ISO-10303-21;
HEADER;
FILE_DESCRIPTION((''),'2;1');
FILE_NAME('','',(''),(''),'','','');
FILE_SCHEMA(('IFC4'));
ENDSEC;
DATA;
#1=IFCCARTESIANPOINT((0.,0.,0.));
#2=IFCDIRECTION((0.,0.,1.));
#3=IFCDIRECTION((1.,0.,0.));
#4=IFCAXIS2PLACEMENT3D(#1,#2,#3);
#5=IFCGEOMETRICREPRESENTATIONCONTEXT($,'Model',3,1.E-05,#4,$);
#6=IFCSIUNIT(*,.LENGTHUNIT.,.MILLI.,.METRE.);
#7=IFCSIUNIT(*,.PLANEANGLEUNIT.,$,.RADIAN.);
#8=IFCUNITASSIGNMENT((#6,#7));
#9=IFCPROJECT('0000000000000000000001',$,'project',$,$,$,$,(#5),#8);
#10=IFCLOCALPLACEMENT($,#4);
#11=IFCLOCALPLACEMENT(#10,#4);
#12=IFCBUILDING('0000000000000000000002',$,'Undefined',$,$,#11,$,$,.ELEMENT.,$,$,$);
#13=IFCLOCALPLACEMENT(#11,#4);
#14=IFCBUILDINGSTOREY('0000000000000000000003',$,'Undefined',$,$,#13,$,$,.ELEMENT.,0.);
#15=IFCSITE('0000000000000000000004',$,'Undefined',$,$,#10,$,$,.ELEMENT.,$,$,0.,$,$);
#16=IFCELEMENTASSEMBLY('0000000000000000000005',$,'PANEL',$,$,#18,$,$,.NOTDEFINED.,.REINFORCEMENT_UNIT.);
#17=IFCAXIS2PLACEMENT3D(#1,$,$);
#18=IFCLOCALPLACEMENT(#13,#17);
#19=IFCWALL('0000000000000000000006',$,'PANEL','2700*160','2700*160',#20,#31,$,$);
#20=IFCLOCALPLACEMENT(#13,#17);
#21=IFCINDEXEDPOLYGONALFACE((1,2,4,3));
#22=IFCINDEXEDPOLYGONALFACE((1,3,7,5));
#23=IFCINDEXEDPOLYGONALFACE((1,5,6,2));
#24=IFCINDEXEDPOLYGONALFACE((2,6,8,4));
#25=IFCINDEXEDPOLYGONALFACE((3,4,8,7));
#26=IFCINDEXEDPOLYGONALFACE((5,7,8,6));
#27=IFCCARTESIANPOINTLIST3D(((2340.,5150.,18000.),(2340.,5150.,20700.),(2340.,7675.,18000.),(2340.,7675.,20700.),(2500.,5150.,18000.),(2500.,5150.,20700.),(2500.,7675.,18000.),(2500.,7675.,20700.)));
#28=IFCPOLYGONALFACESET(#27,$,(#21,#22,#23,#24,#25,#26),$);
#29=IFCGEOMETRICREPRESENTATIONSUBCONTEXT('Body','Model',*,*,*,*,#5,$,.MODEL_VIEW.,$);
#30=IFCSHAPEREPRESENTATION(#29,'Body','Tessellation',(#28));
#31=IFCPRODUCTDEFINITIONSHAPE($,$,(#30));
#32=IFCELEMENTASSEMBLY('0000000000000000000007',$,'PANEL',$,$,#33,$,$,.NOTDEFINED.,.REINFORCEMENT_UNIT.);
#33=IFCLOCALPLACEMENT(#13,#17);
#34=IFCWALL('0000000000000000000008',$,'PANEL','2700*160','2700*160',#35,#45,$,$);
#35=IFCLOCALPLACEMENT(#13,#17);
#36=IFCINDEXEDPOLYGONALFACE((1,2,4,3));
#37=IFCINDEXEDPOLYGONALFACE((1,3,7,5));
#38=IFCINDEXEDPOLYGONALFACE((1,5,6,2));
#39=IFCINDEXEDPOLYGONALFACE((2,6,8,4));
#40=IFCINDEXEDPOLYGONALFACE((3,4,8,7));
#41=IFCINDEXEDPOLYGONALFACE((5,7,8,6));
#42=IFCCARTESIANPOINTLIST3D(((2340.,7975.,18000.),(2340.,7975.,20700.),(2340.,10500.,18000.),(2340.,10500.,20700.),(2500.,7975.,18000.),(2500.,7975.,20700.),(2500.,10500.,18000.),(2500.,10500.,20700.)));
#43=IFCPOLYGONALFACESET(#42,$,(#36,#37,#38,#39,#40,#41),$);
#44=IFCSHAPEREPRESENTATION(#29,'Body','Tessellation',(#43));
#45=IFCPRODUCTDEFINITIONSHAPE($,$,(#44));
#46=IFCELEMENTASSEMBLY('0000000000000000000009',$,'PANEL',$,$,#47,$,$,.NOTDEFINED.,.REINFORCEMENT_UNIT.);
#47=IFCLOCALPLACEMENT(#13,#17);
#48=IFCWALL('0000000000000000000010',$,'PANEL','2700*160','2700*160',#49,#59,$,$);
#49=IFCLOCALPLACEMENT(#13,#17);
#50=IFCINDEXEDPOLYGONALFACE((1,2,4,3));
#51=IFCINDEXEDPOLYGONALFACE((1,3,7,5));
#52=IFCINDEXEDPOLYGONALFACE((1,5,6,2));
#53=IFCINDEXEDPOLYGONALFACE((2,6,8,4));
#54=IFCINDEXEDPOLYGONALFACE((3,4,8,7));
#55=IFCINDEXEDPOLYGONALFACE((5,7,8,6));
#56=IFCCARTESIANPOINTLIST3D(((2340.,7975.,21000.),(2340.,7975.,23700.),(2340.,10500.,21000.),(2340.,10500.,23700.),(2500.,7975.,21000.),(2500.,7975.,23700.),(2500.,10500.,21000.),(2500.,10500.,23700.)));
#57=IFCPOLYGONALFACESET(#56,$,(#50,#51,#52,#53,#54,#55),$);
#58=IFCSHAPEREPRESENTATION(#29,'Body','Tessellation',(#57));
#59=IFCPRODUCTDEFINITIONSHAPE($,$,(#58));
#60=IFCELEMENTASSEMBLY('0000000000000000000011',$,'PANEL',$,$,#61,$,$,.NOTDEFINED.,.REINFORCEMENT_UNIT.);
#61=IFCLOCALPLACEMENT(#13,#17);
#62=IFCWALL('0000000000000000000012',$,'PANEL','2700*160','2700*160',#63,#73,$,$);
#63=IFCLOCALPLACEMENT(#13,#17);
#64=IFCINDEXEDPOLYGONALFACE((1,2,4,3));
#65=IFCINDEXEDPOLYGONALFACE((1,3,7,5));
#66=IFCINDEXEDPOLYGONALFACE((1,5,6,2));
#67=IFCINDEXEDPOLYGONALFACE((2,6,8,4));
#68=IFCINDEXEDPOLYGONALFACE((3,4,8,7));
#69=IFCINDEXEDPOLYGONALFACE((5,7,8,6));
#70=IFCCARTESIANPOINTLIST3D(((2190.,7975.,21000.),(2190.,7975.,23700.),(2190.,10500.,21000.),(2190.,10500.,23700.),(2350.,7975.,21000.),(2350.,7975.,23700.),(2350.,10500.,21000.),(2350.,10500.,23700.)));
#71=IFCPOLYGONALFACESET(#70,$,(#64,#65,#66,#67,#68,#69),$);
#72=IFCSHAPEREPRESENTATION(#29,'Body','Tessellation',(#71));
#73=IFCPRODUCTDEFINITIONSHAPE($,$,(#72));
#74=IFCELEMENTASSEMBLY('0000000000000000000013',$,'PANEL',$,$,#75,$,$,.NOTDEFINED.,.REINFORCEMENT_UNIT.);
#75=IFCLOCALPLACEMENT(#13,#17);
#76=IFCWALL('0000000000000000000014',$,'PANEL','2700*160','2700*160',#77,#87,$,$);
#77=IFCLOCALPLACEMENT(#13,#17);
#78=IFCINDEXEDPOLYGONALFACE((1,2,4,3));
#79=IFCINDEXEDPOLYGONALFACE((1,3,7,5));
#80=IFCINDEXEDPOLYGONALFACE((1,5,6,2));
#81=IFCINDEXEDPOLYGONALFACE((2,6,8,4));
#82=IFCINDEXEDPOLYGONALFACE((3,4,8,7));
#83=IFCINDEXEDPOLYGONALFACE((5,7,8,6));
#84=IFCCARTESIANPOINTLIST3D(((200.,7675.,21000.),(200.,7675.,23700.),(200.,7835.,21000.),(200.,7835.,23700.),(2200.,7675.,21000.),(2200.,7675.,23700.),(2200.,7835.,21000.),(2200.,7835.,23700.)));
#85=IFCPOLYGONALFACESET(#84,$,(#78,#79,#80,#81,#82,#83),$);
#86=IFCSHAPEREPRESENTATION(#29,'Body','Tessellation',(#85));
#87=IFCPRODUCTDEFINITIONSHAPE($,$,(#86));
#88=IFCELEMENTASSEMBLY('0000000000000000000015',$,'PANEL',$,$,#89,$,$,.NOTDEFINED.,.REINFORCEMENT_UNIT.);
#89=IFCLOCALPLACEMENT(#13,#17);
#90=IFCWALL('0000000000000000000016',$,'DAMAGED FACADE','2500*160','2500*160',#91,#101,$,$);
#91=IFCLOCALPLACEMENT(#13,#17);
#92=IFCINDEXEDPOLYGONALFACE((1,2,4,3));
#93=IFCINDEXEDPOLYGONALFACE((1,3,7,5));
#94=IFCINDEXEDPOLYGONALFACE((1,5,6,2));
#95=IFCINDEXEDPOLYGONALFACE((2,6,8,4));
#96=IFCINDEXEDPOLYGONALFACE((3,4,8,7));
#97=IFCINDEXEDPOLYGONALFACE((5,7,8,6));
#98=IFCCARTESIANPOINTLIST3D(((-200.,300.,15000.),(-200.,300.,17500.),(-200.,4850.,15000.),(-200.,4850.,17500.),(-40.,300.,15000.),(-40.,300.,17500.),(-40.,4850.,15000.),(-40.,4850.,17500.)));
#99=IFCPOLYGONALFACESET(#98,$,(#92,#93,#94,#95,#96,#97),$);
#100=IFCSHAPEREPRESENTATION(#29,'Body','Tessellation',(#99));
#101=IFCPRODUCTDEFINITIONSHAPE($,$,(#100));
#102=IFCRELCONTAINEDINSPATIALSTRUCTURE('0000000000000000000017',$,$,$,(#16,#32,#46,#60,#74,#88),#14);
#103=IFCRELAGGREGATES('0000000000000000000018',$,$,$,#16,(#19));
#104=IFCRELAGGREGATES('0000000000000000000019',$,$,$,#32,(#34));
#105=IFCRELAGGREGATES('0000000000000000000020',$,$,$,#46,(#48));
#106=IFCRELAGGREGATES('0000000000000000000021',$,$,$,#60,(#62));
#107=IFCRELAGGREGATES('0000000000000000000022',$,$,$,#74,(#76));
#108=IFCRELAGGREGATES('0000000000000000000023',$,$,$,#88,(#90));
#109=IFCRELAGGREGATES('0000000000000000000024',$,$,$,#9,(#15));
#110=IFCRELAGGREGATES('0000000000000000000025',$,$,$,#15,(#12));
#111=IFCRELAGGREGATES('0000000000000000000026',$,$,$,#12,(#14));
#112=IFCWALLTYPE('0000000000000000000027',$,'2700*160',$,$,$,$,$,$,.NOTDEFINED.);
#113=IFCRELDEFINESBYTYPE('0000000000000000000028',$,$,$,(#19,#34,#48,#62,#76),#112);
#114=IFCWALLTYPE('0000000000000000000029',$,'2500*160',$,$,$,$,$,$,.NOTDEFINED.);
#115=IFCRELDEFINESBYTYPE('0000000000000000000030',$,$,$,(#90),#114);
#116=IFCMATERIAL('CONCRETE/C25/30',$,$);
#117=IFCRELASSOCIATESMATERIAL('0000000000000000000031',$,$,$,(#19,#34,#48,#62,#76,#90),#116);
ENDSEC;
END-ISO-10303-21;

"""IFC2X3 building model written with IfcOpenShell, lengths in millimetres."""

from ifc_helpers import new_model, si_unit, frame, frame_2d, origin_with_axes, place, context, subcontext, project, spatial, rectangle, extrude, material, type_object, element, aggregate, save


model = new_model("IFC2X3")

# Units and contexts
model_context = context("Model", 3, precision=1e-05, world=origin_with_axes())
body_context = subcontext(model_context, "Body", "Model", "MODEL_VIEW")
ifc_project = project(units=[si_unit("LENGTHUNIT", "METRE", prefix="MILLI"), si_unit("PLANEANGLEUNIT", "RADIAN")], contexts=[model_context])

# Site, building, storey
site_placement = place(None, origin_with_axes())
site = spatial("IfcSite", under=ifc_project, at=site_placement, Name="Undefined", CompositionType="ELEMENT", RefElevation=0.0)
building_placement = place(site_placement, origin_with_axes())
building = spatial("IfcBuilding", under=site, at=building_placement, Name="Undefined", CompositionType="ELEMENT")
storey_placement = place(building_placement, origin_with_axes())
storey = spatial("IfcBuildingStorey", under=building, at=storey_placement, Name="Undefined", CompositionType="ELEMENT", Elevation=0.0)

# Shared definitions
ifc_material_1 = material(Name="CONCRETE/C25/30")

# Element assemblies, walls
wall_type_1 = type_object("IfcWallType", Name="2700*160", PredefinedType="NOTDEFINED")
assembly_1_placement = place(storey_placement, origin_with_axes())
assembly_1 = element("IfcElementAssembly", 1, at=assembly_1_placement, inside=storey, Name="PANEL", AssemblyPlace="NOTDEFINED", PredefinedType="REINFORCEMENT_UNIT")
wall_1_placement = place(assembly_1_placement, frame((2420.0, 5150.0, 18000.0), z_axis=(0.0, 0.0, 1.0), x_axis=(0.0, 1.0, 0.0)))
wall_1 = element("IfcWall", 2, at=wall_1_placement, type_object=wall_type_1, material=ifc_material_1, Name="PANEL", Description="2700*160", ObjectType="2700*160", context=body_context, shape_type="SweptSolid", body=[
    extrude(rectangle(XDim=2525.0, YDim=160.0, at=frame_2d((0.0, 1262.5), x_axis=(0.0, -1.0))), frame((0.0, 0.0, 0.0), z_axis=(0.0, 0.0, 1.0), x_axis=(0.0, -1.0, 0.0)), (0.0, 0.0, 1.0), 2700.0),
])
aggregate(assembly_1, [wall_1])
assembly_2_placement = place(storey_placement, origin_with_axes())
assembly_2 = element("IfcElementAssembly", 3, at=assembly_2_placement, inside=storey, Name="PANEL", AssemblyPlace="NOTDEFINED", PredefinedType="REINFORCEMENT_UNIT")
wall_2_placement = place(assembly_2_placement, frame((2420.0, 7975.0, 18000.0), z_axis=(0.0, 0.0, 1.0), x_axis=(0.0, 1.0, 0.0)))
wall_2 = element("IfcWall", 4, at=wall_2_placement, type_object=wall_type_1, material=ifc_material_1, Name="PANEL", Description="2700*160", ObjectType="2700*160", context=body_context, shape_type="SweptSolid", body=[
    extrude(rectangle(XDim=2525.0, YDim=160.0, at=frame_2d((0.0, 1262.5), x_axis=(0.0, -1.0))), frame((0.0, 0.0, 0.0), z_axis=(0.0, 0.0, 1.0), x_axis=(0.0, -1.0, 0.0)), (0.0, 0.0, 1.0), 2700.0),
])
aggregate(assembly_2, [wall_2])
assembly_3_placement = place(storey_placement, origin_with_axes())
assembly_3 = element("IfcElementAssembly", 5, at=assembly_3_placement, inside=storey, Name="PANEL", AssemblyPlace="NOTDEFINED", PredefinedType="REINFORCEMENT_UNIT")
wall_3_placement = place(assembly_3_placement, frame((2420.0, 7975.0, 21000.0), z_axis=(0.0, 0.0, 1.0), x_axis=(0.0, 1.0, 0.0)))
wall_3 = element("IfcWall", 6, at=wall_3_placement, type_object=wall_type_1, material=ifc_material_1, Name="PANEL", Description="2700*160", ObjectType="2700*160", context=body_context, shape_type="SweptSolid", body=[
    extrude(rectangle(XDim=2525.0, YDim=160.0, at=frame_2d((0.0, 1262.5), x_axis=(0.0, -1.0))), frame((0.0, 0.0, 0.0), z_axis=(0.0, 0.0, 1.0), x_axis=(0.0, -1.0, 0.0)), (0.0, 0.0, 1.0), 2700.0),
])
aggregate(assembly_3, [wall_3])
assembly_4_placement = place(storey_placement, origin_with_axes())
assembly_4 = element("IfcElementAssembly", 7, at=assembly_4_placement, inside=storey, Name="PANEL", AssemblyPlace="NOTDEFINED", PredefinedType="REINFORCEMENT_UNIT")
wall_4_placement = place(assembly_4_placement, frame((2270.0, 7975.0, 21000.0), z_axis=(0.0, 0.0, 1.0), x_axis=(0.0, 1.0, 0.0)))
wall_4 = element("IfcWall", 8, at=wall_4_placement, type_object=wall_type_1, material=ifc_material_1, Name="PANEL", Description="2700*160", ObjectType="2700*160", context=body_context, shape_type="SweptSolid", body=[
    extrude(rectangle(XDim=2525.0, YDim=160.0, at=frame_2d((0.0, 1262.5), x_axis=(0.0, -1.0))), frame((0.0, 0.0, 0.0), z_axis=(0.0, 0.0, 1.0), x_axis=(0.0, -1.0, 0.0)), (0.0, 0.0, 1.0), 2700.0),
])
aggregate(assembly_4, [wall_4])
assembly_5_placement = place(storey_placement, origin_with_axes())
assembly_5 = element("IfcElementAssembly", 9, at=assembly_5_placement, inside=storey, Name="PANEL", AssemblyPlace="NOTDEFINED", PredefinedType="REINFORCEMENT_UNIT")
wall_5_placement = place(assembly_5_placement, frame((200.0, 7755.0, 21000.0), z_axis=(0.0, 0.0, 1.0), x_axis=(1.0, 0.0, 0.0)))
wall_5 = element("IfcWall", 10, at=wall_5_placement, type_object=wall_type_1, material=ifc_material_1, Name="PANEL", Description="2700*160", ObjectType="2700*160", context=body_context, shape_type="SweptSolid", body=[
    extrude(rectangle(XDim=2000.0, YDim=160.0, at=frame_2d((0.0, 1000.0), x_axis=(0.0, -1.0))), frame((0.0, 0.0, 0.0), z_axis=(0.0, 0.0, 1.0), x_axis=(0.0, -1.0, 0.0)), (0.0, 0.0, 1.0), 2700.0),
])
aggregate(assembly_5, [wall_5])
assembly_6_placement = place(storey_placement, origin_with_axes())
assembly_6 = element("IfcElementAssembly", 11, at=assembly_6_placement, inside=storey, Name="PANEL", AssemblyPlace="NOTDEFINED", PredefinedType="REINFORCEMENT_UNIT")
wall_type_2 = type_object("IfcWallType", Name="2500*160", PredefinedType="NOTDEFINED")
wall_6_placement = place(assembly_6_placement, frame((-120.0, 4850.0, 15000.0), z_axis=(0.0, 0.0, 1.0), x_axis=(0.0, -1.0, 0.0)))
wall_6 = element("IfcWall", 12, at=wall_6_placement, type_object=wall_type_2, material=ifc_material_1, Name="DAMAGED FACADE", Description="2500*160", ObjectType="2500*160", context=body_context, shape_type="SweptSolid", body=[
    extrude(rectangle(XDim=4550.0, YDim=160.0, at=frame_2d((0.0, 2275.0), x_axis=(0.0, -1.0))), frame((0.0, 0.0, 0.0), z_axis=(0.0, 0.0, 1.0), x_axis=(0.0, -1.0, 0.0)), (0.0, 0.0, 1.0), 2500.0),
])
aggregate(assembly_6, [wall_6])

save(model, "model.ifc")
